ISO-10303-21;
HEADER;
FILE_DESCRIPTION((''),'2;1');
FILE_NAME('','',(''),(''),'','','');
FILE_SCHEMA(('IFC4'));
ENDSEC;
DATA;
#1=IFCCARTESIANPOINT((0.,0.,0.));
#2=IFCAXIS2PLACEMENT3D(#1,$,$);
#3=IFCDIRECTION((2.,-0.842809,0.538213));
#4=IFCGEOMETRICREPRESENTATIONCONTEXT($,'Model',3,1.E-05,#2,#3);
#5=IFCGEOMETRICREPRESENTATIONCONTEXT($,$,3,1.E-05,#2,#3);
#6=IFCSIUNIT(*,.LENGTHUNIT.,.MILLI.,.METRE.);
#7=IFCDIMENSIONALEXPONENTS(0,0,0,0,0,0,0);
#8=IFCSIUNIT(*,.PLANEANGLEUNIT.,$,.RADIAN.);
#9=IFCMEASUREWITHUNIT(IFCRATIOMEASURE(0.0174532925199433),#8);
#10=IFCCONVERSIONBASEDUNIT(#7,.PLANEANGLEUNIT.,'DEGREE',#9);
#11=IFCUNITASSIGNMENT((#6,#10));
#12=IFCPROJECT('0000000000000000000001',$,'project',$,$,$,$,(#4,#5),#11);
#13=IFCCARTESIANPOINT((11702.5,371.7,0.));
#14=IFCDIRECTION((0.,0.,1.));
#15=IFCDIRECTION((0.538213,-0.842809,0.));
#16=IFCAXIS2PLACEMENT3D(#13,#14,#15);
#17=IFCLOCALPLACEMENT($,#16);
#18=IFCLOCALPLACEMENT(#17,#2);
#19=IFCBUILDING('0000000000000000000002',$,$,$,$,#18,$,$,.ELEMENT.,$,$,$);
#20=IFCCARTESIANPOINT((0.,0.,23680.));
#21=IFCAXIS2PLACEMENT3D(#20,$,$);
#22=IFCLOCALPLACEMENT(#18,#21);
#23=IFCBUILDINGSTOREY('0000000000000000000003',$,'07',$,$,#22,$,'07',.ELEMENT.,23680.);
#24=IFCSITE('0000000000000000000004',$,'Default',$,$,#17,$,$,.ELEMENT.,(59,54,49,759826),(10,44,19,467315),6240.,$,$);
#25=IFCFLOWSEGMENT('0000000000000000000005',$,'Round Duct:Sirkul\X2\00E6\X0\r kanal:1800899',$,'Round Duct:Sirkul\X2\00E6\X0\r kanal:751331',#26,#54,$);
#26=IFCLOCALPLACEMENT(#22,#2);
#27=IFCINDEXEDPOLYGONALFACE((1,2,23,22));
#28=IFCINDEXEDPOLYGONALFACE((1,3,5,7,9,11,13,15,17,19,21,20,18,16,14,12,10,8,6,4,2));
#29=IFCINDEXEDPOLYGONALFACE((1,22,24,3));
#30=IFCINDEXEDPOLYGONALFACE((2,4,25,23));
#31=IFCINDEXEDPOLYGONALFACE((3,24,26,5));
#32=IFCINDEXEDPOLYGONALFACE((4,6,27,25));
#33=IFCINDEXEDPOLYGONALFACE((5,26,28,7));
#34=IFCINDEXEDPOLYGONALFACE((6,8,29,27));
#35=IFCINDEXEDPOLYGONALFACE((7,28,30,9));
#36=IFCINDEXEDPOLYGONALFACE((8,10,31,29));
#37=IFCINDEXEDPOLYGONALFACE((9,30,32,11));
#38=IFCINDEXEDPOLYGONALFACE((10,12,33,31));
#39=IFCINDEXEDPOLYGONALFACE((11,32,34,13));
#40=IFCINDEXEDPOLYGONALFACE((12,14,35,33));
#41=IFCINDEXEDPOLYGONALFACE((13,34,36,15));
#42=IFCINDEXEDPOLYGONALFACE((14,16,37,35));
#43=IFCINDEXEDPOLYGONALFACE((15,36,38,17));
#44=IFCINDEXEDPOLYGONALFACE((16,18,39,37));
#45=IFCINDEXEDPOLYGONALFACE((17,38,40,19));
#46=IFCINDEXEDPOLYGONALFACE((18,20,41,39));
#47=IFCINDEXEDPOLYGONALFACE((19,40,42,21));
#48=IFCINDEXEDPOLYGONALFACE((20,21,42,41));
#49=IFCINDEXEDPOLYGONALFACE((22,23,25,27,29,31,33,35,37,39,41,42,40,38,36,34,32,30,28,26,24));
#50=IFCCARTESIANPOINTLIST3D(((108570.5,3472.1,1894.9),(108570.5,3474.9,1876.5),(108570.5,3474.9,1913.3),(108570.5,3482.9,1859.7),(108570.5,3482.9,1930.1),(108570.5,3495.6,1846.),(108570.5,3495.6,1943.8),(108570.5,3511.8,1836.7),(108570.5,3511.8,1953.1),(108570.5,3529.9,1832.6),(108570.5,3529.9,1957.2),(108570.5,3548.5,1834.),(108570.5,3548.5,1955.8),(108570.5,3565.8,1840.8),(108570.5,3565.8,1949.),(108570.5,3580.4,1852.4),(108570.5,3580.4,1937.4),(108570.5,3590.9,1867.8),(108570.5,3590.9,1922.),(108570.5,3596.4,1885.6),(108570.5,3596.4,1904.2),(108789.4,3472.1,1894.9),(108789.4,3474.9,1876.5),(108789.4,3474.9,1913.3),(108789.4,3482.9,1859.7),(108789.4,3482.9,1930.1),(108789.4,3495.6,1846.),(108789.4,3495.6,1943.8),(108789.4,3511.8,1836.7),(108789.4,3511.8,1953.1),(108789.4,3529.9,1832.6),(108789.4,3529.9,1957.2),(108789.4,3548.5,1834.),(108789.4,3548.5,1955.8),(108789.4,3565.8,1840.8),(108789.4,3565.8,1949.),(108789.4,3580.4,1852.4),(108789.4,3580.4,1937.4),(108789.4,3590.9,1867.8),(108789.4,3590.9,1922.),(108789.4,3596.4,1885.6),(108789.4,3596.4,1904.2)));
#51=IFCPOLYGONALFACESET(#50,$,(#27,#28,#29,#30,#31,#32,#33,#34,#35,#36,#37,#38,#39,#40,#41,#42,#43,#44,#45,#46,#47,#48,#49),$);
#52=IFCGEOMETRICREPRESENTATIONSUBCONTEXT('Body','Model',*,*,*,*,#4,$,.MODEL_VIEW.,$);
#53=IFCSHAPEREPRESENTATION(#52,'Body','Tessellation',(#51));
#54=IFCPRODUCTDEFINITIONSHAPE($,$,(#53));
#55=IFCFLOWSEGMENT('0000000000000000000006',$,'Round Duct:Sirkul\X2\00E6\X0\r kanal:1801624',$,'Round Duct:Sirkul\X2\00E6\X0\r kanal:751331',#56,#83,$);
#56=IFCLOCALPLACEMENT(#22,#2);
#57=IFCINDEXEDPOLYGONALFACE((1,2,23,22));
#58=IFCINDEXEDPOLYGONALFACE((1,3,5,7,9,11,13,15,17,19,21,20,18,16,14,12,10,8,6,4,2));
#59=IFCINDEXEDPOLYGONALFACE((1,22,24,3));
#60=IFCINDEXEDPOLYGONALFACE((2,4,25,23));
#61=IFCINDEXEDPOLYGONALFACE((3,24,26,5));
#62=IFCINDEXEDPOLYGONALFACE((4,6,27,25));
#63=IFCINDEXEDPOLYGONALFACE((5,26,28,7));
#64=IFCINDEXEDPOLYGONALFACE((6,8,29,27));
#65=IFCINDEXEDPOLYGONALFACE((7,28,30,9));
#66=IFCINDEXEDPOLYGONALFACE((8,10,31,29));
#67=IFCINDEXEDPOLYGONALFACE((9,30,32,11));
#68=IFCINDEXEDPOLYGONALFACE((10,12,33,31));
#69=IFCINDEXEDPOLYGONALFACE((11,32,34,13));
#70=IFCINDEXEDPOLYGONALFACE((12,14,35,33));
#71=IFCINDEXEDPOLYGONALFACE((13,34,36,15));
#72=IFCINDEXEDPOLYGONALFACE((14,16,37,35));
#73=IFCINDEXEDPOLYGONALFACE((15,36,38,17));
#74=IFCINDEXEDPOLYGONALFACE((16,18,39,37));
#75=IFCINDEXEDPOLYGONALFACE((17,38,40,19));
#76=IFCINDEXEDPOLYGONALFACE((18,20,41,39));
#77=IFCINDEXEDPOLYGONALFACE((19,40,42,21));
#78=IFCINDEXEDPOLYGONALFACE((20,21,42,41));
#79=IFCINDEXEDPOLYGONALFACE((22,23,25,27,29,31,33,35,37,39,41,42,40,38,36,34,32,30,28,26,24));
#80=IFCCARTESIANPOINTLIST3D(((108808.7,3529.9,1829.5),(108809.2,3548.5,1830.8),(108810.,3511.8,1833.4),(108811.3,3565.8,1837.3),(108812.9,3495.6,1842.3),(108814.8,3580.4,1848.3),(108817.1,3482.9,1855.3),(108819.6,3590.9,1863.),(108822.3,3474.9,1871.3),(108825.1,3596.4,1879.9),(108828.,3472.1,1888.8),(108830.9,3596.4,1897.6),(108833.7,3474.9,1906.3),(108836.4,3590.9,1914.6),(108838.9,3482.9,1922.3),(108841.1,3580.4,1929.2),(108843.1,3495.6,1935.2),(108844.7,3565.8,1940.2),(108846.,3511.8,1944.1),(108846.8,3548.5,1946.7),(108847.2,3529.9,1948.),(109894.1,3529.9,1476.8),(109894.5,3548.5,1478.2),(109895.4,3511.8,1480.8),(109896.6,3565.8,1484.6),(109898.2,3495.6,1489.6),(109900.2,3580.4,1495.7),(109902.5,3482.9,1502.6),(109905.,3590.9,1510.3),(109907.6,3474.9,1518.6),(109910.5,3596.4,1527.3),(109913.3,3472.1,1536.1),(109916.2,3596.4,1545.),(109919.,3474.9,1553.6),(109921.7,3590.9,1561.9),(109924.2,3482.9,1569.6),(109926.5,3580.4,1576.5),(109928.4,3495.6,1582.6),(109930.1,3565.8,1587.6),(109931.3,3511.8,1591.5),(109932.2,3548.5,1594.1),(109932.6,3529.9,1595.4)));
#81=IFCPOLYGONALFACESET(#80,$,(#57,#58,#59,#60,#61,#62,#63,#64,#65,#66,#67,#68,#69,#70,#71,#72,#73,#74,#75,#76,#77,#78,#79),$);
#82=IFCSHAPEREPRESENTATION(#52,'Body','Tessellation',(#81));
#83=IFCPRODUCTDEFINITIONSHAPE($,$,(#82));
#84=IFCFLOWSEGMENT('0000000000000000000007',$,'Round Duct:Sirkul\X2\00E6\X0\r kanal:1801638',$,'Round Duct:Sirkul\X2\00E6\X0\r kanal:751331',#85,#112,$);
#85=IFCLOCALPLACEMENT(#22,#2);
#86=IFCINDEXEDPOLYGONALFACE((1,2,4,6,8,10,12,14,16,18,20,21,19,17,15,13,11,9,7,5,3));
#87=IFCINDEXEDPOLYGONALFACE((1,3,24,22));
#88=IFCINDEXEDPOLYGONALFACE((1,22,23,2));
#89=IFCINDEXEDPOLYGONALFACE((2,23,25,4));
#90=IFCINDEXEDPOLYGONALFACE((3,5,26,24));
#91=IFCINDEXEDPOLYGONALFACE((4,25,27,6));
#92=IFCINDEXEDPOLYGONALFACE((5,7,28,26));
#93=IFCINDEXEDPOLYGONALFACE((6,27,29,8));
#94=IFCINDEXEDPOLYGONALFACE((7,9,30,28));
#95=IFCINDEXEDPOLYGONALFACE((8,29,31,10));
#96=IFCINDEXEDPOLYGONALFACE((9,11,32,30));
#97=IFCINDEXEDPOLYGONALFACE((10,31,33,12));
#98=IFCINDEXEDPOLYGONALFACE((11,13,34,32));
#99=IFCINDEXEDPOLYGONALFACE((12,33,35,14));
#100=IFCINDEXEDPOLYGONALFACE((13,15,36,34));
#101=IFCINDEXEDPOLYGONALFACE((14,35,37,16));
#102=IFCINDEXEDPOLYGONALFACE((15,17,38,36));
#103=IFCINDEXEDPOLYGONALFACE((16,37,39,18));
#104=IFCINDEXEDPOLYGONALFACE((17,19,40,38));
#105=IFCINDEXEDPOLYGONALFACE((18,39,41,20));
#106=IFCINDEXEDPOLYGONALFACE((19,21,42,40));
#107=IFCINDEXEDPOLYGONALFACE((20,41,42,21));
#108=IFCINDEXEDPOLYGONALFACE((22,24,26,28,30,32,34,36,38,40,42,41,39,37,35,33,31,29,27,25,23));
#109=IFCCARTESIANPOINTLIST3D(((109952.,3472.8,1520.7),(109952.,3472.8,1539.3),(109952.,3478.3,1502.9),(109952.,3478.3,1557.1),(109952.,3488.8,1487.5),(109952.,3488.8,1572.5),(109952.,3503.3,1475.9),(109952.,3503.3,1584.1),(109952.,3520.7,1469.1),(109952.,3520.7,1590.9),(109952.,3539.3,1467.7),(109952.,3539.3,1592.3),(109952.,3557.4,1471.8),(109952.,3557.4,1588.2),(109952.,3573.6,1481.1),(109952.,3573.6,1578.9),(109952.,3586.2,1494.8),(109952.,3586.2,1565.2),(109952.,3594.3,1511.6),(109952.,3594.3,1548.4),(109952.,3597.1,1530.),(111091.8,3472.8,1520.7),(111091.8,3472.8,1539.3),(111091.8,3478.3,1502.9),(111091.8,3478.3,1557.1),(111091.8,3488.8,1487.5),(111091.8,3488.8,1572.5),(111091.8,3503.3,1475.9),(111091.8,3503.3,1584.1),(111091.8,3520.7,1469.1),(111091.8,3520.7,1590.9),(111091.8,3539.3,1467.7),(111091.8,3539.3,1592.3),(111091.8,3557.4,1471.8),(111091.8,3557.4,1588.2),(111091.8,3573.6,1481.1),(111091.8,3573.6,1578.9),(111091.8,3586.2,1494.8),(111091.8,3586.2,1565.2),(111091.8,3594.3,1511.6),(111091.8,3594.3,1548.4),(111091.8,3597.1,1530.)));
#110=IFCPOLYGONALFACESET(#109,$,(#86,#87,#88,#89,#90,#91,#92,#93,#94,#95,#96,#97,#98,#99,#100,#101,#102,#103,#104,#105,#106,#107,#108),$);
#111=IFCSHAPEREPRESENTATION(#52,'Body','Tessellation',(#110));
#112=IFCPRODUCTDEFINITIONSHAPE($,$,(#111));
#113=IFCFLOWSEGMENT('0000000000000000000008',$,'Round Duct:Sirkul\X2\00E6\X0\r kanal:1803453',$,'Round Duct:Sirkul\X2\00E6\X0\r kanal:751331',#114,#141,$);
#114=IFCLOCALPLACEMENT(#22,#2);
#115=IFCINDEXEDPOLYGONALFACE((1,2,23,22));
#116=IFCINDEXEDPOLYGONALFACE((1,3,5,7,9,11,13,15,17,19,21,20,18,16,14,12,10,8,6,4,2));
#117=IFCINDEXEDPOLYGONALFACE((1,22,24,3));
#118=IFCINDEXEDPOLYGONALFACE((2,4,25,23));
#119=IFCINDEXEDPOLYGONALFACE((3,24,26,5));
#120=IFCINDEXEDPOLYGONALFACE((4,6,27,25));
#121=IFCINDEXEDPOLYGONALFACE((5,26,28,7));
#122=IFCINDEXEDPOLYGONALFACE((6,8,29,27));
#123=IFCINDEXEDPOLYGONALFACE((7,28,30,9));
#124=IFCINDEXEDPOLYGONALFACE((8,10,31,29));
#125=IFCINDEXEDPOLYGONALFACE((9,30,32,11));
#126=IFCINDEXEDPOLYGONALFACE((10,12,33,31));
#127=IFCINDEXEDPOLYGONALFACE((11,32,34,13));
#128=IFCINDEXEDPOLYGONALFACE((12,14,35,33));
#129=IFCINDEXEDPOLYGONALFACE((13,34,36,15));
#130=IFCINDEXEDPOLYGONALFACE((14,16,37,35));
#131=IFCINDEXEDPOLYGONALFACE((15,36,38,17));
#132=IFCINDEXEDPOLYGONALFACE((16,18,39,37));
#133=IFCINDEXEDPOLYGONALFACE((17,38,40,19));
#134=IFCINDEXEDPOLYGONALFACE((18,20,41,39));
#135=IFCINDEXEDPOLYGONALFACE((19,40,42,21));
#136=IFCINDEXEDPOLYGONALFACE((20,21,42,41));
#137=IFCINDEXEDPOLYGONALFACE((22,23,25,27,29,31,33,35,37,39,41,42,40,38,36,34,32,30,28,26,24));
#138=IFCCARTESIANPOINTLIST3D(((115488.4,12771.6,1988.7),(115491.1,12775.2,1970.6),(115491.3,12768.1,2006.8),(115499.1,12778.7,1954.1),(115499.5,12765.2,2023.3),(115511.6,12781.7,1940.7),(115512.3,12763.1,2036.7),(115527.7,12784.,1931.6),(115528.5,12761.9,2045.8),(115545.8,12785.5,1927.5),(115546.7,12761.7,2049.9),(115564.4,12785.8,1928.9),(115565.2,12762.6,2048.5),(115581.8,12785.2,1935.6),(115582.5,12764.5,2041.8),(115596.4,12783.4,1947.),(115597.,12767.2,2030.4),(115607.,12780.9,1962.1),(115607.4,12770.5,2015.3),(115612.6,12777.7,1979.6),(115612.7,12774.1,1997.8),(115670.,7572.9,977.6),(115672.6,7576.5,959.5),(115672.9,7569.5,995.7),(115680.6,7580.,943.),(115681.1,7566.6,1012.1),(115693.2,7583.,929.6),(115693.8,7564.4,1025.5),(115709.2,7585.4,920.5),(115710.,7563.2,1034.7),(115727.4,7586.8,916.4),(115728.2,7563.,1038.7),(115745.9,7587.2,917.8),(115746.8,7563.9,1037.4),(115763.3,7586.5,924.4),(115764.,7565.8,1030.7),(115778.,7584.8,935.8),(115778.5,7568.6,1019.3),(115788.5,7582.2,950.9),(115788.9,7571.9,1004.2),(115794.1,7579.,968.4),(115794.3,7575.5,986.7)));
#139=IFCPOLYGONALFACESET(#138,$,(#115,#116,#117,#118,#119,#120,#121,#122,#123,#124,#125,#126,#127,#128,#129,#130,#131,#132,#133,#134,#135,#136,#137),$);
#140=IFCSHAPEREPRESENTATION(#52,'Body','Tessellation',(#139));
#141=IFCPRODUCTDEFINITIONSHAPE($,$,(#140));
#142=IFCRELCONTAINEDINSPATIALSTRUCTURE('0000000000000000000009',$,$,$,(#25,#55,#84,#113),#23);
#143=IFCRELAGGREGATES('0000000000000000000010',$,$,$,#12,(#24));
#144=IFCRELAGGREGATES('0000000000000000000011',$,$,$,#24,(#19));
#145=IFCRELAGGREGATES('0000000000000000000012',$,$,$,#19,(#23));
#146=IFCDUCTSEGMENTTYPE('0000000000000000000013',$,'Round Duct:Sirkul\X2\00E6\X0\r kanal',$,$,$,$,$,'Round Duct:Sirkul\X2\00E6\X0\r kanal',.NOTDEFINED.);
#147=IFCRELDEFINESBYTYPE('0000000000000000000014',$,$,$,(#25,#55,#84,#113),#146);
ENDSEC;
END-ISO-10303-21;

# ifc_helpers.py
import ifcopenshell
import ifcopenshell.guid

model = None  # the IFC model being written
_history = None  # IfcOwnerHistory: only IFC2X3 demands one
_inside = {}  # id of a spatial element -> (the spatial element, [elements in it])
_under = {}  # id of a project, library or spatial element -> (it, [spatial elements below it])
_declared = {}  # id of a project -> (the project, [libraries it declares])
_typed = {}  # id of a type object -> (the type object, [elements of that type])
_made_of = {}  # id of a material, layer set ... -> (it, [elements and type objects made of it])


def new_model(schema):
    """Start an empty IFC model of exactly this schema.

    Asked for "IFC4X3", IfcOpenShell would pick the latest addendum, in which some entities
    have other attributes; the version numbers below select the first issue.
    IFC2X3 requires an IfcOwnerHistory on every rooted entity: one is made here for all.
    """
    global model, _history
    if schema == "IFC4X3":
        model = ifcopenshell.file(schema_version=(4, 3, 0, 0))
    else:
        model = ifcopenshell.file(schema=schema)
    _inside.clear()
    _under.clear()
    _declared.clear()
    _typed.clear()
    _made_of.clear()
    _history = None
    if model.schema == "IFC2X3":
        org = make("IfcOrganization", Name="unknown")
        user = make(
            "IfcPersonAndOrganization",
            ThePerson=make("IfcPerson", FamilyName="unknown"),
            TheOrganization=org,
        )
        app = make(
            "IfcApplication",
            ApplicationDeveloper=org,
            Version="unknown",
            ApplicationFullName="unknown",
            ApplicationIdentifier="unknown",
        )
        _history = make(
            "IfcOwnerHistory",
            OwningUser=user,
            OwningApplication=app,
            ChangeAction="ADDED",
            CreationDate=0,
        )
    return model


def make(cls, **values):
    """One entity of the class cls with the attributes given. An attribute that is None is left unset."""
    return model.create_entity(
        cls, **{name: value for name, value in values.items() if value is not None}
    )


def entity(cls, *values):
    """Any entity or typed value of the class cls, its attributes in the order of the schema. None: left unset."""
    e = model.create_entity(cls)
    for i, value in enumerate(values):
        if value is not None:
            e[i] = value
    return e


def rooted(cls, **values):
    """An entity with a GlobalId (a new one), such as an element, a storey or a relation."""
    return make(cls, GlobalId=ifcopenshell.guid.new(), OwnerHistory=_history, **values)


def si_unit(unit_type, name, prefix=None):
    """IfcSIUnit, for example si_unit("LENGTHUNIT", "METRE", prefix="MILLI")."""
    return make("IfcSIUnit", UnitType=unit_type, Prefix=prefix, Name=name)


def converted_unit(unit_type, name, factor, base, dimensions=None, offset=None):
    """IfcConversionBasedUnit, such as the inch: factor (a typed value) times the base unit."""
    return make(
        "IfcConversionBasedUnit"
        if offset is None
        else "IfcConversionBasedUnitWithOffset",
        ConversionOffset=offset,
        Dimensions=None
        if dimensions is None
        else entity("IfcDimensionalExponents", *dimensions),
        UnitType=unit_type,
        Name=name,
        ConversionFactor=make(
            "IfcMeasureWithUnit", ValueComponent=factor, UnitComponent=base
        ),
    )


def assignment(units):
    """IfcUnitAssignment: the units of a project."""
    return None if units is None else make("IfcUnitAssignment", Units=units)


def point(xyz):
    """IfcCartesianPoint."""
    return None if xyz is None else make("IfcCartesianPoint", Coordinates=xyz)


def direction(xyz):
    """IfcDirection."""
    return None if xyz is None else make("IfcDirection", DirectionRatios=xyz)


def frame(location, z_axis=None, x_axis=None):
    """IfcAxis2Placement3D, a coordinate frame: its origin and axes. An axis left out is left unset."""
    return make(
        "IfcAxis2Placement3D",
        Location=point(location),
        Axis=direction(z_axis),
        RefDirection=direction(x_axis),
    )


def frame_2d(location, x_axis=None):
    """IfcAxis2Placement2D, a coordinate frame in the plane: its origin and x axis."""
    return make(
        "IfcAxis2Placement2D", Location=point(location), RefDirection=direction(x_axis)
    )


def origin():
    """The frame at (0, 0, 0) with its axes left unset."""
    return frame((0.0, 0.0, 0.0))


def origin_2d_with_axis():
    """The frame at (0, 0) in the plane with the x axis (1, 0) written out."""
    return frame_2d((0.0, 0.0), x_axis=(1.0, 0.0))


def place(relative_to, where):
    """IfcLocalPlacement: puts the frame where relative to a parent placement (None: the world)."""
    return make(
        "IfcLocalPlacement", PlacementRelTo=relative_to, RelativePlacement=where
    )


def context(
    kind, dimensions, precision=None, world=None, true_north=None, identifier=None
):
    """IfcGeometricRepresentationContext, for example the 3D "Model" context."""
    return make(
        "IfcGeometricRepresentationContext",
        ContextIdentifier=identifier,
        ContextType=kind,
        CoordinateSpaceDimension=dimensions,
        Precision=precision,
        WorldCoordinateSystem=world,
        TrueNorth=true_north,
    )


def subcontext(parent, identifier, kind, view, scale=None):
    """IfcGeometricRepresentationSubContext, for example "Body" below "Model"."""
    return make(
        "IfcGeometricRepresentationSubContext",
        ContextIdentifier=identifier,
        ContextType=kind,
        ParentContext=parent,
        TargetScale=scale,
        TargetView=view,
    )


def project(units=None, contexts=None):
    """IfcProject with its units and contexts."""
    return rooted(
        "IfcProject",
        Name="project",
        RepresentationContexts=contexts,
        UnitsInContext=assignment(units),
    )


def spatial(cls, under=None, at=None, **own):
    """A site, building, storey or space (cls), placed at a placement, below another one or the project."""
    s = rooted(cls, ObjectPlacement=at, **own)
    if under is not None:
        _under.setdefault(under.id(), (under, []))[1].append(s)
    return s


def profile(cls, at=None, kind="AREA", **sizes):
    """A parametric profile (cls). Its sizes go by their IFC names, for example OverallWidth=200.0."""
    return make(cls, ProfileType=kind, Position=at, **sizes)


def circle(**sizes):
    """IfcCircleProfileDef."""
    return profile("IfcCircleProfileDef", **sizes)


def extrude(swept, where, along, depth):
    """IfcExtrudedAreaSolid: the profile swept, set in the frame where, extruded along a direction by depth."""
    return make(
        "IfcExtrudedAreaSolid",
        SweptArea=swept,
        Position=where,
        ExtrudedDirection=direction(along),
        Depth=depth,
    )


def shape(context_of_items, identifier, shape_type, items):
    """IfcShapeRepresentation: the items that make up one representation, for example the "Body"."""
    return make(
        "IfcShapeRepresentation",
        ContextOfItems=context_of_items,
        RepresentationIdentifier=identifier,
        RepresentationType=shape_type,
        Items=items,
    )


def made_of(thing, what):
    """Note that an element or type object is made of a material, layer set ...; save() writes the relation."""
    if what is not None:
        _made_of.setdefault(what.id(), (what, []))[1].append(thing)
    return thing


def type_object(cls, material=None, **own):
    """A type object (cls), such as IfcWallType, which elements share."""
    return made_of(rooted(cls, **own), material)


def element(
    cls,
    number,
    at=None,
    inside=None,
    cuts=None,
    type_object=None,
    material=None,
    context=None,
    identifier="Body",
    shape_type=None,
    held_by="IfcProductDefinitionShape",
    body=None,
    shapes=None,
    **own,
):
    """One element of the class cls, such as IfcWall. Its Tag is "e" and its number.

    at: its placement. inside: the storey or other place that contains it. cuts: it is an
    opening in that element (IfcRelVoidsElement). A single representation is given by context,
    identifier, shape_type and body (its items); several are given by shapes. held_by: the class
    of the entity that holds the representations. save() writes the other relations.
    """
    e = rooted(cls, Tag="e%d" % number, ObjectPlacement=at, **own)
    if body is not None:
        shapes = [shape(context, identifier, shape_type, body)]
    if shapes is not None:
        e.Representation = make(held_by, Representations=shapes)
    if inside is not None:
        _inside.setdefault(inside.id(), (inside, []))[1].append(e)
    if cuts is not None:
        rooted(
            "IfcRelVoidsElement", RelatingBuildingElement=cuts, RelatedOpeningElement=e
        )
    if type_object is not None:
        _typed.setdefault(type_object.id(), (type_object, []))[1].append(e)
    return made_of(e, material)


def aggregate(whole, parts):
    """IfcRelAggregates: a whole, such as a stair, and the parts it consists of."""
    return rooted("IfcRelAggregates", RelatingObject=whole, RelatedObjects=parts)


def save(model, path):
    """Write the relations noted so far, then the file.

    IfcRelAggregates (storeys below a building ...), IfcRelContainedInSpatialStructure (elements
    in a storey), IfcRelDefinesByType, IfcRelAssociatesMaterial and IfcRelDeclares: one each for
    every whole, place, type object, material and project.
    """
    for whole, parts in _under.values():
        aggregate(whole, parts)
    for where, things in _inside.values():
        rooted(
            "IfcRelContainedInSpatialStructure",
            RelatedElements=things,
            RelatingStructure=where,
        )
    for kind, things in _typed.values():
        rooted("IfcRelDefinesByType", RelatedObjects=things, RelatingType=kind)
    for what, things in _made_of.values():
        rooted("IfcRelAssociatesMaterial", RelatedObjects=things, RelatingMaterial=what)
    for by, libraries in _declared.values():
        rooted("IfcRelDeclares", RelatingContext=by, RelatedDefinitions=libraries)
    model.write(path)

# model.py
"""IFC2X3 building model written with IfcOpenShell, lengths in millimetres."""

from ifc_helpers import new_model, entity, si_unit, converted_unit, direction, frame, frame_2d, origin, origin_2d_with_axis, place, context, subcontext, project, spatial, circle, extrude, type_object, element, save


model = new_model("IFC2X3")

# Units and contexts
model_context = context("Model", 3, precision=1e-05, world=origin(), true_north=direction((2.0, -0.842809, 0.538213)))
context_of_model = context(None, 3, precision=1e-05, world=origin(), true_north=direction((2.0, -0.842809, 0.538213)))
body_context = subcontext(model_context, "Body", "Model", "MODEL_VIEW")
ifc_project = project(units=[si_unit("LENGTHUNIT", "METRE", prefix="MILLI"), converted_unit("PLANEANGLEUNIT", "DEGREE", entity("IfcRatioMeasure", 0.0174532925199433), si_unit("PLANEANGLEUNIT", "RADIAN"), dimensions=[0, 0, 0, 0, 0, 0, 0])], contexts=[model_context, context_of_model])

# Site, building, storey
site_placement = place(None, frame((11702.5, 371.7, 0.0), z_axis=(0.0, 0.0, 1.0), x_axis=(0.538213, -0.842809, 0.0)))
site = spatial("IfcSite", under=ifc_project, at=site_placement, Name="Default", CompositionType="ELEMENT", RefLatitude=(59, 54, 49, 759826), RefLongitude=(10, 44, 19, 467315), RefElevation=6240.0)
building_placement = place(site_placement, origin())
building = spatial("IfcBuilding", under=site, at=building_placement, CompositionType="ELEMENT")
storey_placement = place(building_placement, frame((0.0, 0.0, 23680.0)))
storey = spatial("IfcBuildingStorey", under=building, at=storey_placement, Name="07", LongName="07", CompositionType="ELEMENT", Elevation=23680.0)

# Flow segments
duct_segment_type = type_object("IfcDuctSegmentType", Name="Round Duct:Sirkulær kanal", ElementType="Round Duct:Sirkulær kanal", PredefinedType="NOTDEFINED")
flow_segment_1_placement = place(storey_placement, origin())
element("IfcFlowSegment", 1, at=flow_segment_1_placement, inside=storey, type_object=duct_segment_type, Name="Round Duct:Sirkulær kanal:1800899", ObjectType="Round Duct:Sirkulær kanal:751331", context=body_context, shape_type="SweptSolid", body=[
    extrude(circle(Radius=62.5, at=origin_2d_with_axis()), frame((108570.5, 3534.6, 1894.9), z_axis=(1.0, 0.0, 0.0), x_axis=(0.0, -1.0, 0.0)), (0.0, 0.0, 1.0), 218.9),
])
flow_segment_2_placement = place(storey_placement, origin())
element("IfcFlowSegment", 2, at=flow_segment_2_placement, inside=storey, type_object=duct_segment_type, Name="Round Duct:Sirkulær kanal:1801624", ObjectType="Round Duct:Sirkulær kanal:751331", context=body_context, shape_type="SweptSolid", body=[
    extrude(circle(Radius=62.5, at=frame_2d((0.0, 0.0), x_axis=(1.0, 0.0))), frame((109913.3, 3534.6, 1536.1), z_axis=(-0.951057, 0.0, 0.309017), x_axis=(0.0, -1.0, 0.0)), (0.0, 0.0, 1.0), 1141.2),
])
flow_segment_3_placement = place(storey_placement, origin())
element("IfcFlowSegment", 3, at=flow_segment_3_placement, inside=storey, type_object=duct_segment_type, Name="Round Duct:Sirkulær kanal:1801638", ObjectType="Round Duct:Sirkulær kanal:751331", context=body_context, shape_type="SweptSolid", body=[
    extrude(circle(Radius=62.5, at=frame_2d((0.0, 0.0), x_axis=(1.0, 0.0))), frame((109952.0, 3534.6, 1530.0), z_axis=(1.0, 0.0, 0.0), x_axis=(0.0, 1.0, 0.0)), (0.0, 0.0, 1.0), 1139.8),
])
flow_segment_4_placement = place(storey_placement, origin())
element("IfcFlowSegment", 4, at=flow_segment_4_placement, inside=storey, type_object=duct_segment_type, Name="Round Duct:Sirkulær kanal:1803453", ObjectType="Round Duct:Sirkulær kanal:751331", context=body_context, shape_type="SweptSolid", body=[
    extrude(circle(Radius=62.5, at=frame_2d((0.0, 0.0), x_axis=(1.0, 0.0))), frame((115732.4, 7575.1, 977.6), z_axis=(-0.034258, 0.981029, 0.190809), x_axis=(-0.999391, -0.034899, 0.0)), (0.0, 0.0, 1.0), 5299.2),
])

save(model, "model.ifc")
